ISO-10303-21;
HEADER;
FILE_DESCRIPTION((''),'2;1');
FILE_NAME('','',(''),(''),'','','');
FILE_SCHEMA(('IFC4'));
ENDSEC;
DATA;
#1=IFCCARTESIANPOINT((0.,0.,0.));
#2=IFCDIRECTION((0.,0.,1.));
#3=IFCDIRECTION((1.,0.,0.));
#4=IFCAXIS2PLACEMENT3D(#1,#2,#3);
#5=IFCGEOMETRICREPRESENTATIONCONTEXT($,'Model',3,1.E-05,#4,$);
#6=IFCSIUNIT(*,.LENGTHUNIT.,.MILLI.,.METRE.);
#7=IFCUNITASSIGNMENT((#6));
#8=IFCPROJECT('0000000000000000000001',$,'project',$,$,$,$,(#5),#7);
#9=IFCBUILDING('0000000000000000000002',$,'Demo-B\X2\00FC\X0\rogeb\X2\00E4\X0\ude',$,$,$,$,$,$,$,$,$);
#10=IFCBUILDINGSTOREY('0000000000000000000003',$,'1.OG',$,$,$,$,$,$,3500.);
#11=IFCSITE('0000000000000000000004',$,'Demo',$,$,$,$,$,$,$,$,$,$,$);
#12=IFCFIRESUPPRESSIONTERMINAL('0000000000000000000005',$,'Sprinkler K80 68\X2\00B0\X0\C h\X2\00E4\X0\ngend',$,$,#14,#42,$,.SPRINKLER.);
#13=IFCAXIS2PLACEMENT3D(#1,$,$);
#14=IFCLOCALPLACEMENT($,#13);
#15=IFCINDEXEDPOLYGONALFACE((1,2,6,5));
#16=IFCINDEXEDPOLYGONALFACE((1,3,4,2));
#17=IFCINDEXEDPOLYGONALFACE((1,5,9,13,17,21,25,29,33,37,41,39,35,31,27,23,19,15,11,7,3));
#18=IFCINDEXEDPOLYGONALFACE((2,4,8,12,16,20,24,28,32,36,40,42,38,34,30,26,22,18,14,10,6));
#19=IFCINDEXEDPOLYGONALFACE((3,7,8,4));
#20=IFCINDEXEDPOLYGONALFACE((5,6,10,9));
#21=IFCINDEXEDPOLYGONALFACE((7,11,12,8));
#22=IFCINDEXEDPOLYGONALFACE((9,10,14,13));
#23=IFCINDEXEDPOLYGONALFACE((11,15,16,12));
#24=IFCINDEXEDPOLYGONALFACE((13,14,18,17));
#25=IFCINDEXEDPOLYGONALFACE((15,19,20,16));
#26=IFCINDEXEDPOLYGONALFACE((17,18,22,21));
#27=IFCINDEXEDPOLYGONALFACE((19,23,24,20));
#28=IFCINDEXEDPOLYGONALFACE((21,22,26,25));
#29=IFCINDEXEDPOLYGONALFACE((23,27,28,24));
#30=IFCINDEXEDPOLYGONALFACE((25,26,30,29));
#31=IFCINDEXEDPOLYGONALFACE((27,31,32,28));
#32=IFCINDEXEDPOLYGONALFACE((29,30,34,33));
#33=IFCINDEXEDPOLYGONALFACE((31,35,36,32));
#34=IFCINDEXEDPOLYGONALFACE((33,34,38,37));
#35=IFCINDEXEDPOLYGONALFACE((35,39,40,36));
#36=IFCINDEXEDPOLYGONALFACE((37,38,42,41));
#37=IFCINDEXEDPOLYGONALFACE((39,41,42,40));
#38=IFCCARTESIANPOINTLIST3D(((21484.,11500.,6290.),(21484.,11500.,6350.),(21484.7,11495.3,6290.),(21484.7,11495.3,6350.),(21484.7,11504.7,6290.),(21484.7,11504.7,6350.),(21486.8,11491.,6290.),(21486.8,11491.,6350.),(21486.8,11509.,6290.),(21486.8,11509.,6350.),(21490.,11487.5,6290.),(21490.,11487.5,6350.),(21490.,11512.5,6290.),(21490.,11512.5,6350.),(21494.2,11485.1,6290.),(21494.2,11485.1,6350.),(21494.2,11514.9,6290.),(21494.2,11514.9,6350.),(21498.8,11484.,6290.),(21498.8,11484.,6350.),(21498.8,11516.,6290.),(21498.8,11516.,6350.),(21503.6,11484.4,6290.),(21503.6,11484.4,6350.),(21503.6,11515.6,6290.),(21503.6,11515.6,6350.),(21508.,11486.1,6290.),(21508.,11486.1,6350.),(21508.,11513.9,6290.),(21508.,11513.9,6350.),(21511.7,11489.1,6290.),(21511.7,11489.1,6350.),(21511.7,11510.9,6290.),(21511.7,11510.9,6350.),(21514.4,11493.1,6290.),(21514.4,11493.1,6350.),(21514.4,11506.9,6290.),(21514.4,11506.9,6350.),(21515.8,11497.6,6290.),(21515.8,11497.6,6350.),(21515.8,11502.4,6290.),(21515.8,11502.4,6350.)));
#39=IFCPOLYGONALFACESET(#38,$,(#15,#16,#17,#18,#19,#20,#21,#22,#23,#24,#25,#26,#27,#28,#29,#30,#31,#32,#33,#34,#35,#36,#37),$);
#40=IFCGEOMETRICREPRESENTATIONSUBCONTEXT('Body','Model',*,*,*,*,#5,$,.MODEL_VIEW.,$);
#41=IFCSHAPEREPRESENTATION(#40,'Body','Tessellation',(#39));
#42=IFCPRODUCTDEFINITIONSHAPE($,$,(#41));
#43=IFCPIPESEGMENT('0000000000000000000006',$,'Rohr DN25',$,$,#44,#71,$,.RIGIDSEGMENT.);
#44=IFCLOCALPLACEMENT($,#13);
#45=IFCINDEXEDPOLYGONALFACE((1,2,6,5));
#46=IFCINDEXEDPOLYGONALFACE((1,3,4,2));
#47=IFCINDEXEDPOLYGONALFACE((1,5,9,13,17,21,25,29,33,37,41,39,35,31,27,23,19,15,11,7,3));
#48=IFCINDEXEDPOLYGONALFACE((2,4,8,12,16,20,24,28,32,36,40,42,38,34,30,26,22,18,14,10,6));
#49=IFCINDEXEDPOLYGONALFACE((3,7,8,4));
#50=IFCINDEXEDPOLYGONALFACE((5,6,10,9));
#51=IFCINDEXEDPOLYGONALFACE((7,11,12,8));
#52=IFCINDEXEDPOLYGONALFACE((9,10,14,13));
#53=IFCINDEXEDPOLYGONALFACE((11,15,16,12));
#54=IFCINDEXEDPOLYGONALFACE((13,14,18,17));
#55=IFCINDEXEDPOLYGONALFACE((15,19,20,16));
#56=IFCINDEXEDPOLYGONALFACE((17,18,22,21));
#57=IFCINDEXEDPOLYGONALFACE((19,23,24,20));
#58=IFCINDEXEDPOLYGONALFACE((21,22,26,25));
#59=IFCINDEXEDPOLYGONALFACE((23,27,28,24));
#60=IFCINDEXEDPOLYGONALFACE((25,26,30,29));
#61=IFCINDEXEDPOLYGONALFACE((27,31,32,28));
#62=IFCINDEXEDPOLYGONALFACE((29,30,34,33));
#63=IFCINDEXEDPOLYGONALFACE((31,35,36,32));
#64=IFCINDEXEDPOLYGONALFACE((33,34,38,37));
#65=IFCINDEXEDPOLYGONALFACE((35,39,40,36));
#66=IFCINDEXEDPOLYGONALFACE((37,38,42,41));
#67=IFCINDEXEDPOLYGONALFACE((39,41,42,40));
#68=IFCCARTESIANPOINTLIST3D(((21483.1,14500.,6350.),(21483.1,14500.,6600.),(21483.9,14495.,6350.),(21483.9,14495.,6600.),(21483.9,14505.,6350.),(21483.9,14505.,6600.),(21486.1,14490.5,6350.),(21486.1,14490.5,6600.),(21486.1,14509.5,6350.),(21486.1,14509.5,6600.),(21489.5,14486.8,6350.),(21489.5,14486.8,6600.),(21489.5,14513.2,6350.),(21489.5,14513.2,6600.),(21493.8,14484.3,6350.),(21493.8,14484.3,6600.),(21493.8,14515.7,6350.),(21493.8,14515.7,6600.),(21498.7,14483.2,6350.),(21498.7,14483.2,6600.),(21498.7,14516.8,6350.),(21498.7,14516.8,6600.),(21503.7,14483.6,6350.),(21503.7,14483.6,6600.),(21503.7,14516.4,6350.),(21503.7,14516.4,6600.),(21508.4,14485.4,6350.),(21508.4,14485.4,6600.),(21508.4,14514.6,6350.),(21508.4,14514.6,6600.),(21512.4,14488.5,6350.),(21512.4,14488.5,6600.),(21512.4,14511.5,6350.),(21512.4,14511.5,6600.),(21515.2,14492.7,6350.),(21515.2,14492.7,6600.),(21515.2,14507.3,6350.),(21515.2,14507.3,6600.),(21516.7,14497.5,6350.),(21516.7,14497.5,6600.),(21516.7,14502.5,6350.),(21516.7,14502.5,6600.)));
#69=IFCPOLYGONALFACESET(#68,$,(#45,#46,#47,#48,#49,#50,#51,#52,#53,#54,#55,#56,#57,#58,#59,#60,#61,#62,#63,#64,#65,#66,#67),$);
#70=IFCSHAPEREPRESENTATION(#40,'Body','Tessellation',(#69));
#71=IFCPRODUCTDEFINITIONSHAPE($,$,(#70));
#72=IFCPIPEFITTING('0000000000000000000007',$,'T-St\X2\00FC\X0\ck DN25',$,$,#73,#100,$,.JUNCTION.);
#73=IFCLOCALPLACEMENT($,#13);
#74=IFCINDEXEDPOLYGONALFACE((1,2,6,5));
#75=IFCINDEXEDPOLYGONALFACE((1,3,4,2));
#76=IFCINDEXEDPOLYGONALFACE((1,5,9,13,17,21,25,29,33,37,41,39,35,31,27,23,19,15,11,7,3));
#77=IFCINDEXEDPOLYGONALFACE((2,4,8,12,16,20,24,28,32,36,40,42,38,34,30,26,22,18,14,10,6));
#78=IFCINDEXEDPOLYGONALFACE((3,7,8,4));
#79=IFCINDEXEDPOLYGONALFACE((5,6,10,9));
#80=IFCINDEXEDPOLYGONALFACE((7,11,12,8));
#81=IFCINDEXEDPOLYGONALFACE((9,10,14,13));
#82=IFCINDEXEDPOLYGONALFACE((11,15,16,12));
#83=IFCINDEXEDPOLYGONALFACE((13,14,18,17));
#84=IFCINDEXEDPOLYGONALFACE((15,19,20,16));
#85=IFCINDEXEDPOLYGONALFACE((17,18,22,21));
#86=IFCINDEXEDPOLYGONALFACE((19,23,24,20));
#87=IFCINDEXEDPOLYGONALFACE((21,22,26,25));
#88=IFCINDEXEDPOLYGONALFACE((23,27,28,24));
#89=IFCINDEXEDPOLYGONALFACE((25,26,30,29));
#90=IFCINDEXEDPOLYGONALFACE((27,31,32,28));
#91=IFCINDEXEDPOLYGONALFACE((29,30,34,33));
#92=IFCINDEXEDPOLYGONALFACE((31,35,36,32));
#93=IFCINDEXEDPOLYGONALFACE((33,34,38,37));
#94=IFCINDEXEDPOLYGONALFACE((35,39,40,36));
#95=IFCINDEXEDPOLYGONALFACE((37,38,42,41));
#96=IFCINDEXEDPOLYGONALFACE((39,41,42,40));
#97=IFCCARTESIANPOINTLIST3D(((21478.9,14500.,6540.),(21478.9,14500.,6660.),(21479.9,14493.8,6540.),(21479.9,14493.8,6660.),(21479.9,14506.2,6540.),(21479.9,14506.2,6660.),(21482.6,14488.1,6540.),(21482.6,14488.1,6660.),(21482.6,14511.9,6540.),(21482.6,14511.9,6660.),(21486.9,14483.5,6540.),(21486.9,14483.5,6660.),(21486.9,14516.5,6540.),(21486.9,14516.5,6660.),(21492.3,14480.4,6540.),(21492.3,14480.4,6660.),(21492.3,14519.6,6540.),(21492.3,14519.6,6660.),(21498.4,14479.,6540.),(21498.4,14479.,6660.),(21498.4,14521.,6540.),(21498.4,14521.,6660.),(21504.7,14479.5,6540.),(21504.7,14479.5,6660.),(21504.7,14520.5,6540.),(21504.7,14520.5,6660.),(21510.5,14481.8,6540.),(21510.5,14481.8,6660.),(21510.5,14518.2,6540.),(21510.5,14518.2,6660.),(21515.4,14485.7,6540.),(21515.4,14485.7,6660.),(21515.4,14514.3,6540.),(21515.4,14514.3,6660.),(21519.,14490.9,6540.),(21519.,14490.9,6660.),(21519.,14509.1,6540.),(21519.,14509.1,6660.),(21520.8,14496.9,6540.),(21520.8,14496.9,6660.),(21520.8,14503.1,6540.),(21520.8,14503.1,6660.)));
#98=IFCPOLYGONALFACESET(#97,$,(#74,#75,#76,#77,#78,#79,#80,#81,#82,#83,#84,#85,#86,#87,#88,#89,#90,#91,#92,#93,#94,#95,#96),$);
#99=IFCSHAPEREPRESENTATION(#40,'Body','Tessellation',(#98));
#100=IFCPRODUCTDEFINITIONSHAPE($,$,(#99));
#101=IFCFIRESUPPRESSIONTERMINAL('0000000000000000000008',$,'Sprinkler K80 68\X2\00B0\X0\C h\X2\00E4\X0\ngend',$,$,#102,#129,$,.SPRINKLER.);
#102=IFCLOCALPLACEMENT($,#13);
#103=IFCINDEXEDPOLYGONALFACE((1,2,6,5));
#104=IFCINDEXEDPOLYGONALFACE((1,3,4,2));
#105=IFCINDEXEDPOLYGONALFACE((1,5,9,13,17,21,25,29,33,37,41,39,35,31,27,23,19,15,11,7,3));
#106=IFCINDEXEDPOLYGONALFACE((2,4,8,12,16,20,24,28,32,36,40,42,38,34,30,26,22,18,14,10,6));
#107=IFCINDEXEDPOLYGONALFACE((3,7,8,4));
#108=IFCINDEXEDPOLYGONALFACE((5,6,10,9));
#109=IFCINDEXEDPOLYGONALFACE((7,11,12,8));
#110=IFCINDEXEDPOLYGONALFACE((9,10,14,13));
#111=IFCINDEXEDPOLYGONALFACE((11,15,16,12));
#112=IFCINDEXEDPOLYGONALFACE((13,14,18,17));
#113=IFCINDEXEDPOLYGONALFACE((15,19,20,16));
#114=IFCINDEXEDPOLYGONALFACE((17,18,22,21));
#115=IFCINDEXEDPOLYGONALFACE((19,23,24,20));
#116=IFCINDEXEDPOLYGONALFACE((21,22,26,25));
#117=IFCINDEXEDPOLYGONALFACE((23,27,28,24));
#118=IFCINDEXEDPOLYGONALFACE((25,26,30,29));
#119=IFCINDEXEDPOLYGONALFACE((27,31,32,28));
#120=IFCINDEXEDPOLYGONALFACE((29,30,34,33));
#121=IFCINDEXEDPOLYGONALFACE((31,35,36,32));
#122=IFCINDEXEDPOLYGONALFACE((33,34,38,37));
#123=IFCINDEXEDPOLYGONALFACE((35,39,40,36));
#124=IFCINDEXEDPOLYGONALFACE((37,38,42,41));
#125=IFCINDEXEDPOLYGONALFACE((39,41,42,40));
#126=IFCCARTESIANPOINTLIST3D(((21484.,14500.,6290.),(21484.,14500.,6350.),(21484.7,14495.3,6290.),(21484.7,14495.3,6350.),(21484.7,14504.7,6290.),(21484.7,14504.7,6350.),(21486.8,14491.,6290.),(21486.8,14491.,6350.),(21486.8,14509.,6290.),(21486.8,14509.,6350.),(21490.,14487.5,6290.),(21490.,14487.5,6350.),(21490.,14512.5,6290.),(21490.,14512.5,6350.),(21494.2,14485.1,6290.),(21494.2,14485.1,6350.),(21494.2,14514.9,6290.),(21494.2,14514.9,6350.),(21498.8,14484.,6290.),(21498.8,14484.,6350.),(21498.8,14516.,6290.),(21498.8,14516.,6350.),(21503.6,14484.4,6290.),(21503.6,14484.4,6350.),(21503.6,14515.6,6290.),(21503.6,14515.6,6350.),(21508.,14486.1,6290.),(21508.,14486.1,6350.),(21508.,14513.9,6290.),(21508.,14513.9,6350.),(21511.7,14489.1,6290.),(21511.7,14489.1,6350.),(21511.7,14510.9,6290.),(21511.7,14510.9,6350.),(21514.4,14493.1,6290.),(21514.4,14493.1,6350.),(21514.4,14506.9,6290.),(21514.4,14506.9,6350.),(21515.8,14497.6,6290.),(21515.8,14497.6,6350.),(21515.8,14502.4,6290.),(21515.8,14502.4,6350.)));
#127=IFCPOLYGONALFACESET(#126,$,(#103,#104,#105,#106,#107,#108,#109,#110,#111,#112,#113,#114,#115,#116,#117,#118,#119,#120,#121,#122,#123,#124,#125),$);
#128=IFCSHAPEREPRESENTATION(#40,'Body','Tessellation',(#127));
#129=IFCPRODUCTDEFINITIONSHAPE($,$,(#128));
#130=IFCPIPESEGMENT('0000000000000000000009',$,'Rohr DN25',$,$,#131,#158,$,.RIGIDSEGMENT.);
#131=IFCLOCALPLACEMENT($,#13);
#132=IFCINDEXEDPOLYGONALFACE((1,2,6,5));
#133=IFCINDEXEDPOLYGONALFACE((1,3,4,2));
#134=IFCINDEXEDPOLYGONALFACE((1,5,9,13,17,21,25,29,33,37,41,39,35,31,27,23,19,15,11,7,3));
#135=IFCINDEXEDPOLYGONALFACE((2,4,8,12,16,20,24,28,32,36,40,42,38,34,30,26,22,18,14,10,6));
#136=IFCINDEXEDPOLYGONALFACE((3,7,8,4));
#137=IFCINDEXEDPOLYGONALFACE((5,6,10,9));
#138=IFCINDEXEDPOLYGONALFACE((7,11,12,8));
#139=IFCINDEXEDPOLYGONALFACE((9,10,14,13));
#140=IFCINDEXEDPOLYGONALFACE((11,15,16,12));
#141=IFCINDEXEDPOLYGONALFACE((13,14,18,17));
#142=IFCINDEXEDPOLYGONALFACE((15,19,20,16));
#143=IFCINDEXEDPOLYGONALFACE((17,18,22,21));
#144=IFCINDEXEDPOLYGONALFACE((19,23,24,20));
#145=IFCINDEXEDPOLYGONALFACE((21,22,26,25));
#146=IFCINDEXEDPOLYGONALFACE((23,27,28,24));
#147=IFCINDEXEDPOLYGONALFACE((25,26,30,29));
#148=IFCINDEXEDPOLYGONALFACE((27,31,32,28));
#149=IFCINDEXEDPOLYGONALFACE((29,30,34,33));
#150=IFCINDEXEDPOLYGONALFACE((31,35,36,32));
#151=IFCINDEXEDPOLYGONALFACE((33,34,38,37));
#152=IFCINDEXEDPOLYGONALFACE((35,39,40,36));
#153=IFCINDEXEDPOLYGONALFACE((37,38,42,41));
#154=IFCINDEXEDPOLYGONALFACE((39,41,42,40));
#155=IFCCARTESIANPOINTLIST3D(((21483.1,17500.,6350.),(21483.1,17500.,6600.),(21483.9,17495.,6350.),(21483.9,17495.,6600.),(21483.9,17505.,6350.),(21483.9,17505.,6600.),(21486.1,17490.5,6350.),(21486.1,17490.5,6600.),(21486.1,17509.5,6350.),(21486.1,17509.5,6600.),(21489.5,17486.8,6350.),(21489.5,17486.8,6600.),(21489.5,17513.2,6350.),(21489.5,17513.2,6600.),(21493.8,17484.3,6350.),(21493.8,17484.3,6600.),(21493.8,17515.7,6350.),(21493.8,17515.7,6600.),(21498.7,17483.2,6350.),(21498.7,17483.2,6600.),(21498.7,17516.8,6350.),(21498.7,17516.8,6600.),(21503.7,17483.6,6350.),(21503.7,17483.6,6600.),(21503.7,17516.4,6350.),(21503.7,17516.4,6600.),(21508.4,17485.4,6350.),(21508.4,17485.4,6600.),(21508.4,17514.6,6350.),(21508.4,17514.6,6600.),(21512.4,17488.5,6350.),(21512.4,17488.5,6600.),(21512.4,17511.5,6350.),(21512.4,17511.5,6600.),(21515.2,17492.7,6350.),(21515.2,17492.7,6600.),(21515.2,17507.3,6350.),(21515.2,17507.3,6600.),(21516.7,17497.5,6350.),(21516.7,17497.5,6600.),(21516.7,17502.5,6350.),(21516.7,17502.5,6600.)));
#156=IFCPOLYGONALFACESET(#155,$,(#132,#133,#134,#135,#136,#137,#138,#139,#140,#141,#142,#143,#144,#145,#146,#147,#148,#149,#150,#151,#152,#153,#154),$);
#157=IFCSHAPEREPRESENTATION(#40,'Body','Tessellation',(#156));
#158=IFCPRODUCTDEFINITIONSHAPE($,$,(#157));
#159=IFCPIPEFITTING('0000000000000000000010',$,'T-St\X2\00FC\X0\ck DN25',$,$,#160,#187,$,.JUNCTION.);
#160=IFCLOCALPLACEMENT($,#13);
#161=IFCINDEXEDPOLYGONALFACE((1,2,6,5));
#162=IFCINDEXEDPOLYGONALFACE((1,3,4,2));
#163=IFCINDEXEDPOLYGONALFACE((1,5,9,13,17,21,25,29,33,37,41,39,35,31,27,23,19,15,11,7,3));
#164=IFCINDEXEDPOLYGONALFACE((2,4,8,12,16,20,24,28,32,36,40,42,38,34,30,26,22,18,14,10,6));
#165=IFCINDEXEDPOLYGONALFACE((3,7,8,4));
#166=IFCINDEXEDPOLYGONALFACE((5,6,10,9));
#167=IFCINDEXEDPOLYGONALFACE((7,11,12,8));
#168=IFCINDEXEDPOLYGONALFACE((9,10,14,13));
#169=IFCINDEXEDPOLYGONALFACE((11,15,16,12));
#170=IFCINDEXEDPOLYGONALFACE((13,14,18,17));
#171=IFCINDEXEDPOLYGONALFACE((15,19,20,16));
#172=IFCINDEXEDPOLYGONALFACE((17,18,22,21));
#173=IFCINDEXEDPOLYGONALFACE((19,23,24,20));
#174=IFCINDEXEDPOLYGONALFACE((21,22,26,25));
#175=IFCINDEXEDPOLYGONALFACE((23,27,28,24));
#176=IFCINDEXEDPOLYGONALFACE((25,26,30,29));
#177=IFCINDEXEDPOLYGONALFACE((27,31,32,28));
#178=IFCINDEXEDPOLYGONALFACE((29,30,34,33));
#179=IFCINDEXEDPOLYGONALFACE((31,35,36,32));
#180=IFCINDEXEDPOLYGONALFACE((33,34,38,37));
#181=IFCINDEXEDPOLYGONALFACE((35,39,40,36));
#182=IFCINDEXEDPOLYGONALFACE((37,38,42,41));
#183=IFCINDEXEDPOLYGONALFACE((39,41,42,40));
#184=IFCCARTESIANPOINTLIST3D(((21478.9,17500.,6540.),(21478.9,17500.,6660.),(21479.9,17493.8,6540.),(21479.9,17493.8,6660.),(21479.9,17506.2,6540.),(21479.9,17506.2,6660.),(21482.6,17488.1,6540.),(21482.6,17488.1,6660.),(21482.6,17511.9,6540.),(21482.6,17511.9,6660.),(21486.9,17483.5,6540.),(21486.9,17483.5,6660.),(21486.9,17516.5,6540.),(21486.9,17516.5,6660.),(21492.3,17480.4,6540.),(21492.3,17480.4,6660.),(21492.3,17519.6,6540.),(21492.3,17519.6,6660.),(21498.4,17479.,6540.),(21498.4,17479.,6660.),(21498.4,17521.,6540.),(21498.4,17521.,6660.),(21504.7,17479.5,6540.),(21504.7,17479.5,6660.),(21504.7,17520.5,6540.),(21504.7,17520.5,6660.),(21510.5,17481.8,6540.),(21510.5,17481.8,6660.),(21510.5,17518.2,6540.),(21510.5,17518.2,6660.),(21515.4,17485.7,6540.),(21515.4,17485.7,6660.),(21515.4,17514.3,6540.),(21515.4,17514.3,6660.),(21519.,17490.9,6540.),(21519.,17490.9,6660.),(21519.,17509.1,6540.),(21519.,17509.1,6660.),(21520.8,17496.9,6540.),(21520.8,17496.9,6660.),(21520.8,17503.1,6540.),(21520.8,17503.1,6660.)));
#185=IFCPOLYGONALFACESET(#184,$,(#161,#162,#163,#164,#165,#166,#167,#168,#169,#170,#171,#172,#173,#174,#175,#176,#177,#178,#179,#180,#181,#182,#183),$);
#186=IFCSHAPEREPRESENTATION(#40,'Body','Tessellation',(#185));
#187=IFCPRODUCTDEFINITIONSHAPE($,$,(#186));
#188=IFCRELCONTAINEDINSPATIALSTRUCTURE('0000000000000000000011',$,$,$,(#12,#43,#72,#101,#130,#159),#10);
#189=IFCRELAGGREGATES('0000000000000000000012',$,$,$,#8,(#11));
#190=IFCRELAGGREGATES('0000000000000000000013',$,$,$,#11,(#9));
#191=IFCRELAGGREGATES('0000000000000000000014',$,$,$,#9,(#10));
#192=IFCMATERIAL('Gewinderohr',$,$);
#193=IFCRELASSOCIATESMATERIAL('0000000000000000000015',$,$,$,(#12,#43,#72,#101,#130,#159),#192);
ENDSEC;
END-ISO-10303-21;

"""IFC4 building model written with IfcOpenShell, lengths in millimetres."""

from ifc_helpers import new_model, si_unit, frame, origin_with_axes, place, context, subcontext, project, spatial, circle, extrude, material, element, save


model = new_model("IFC4")

# Units and contexts
model_context = context("Model", 3, precision=1e-05, world=origin_with_axes())
body_context = subcontext(model_context, "Body", "Model", "MODEL_VIEW")
ifc_project = project(units=[si_unit("LENGTHUNIT", "METRE", prefix="MILLI")], contexts=[model_context])

# Site, building, storey
site = spatial("IfcSite", under=ifc_project, Name="Demo")
building = spatial("IfcBuilding", under=site, Name="Demo-Bürogebäude")
storey = spatial("IfcBuildingStorey", under=building, Name="1.OG", Elevation=3500.0)

# Shared definitions
ifc_material_1 = material(Name="Gewinderohr")

# Fire suppression terminal
fire_suppression_terminal_1_placement = place(None, frame((21500.0, 11500.0, 6350.0), z_axis=(0.0, 0.0, -1.0), x_axis=(-1.0, 0.0, 0.0)))
element("IfcFireSuppressionTerminal", 1, at=fire_suppression_terminal_1_placement, inside=storey, material=ifc_material_1, Name="Sprinkler K80 68°C hängend", PredefinedType="SPRINKLER", context=body_context, shape_type="SweptSolid", body=[
    extrude(circle(Radius=16.0), origin_with_axes(), (0.0, 0.0, 1.0), 60.0),
])

# Pipe segment
pipe_segment_1_placement = place(None, frame((21500.0, 14500.0, 6600.0), z_axis=(0.0, 0.0, -1.0), x_axis=(-1.0, 0.0, 0.0)))
element("IfcPipeSegment", 2, at=pipe_segment_1_placement, inside=storey, material=ifc_material_1, Name="Rohr DN25", PredefinedType="RIGIDSEGMENT", context=body_context, shape_type="SweptSolid", body=[
    extrude(circle(Radius=16.9), origin_with_axes(), (0.0, 0.0, 1.0), 250.0),
])

# Pipe fitting
pipe_fitting_1_placement = place(None, frame((21500.0, 14500.0, 6660.0), z_axis=(0.0, 0.0, -1.0), x_axis=(-1.0, 0.0, 0.0)))
element("IfcPipeFitting", 3, at=pipe_fitting_1_placement, inside=storey, material=ifc_material_1, Name="T-Stück DN25", PredefinedType="JUNCTION", context=body_context, shape_type="SweptSolid", body=[
    extrude(circle(Radius=21.1), origin_with_axes(), (0.0, 0.0, 1.0), 120.0),
])

# Fire suppression terminal
fire_suppression_terminal_2_placement = place(None, frame((21500.0, 14500.0, 6350.0), z_axis=(0.0, 0.0, -1.0), x_axis=(-1.0, 0.0, 0.0)))
element("IfcFireSuppressionTerminal", 4, at=fire_suppression_terminal_2_placement, inside=storey, material=ifc_material_1, Name="Sprinkler K80 68°C hängend", PredefinedType="SPRINKLER", context=body_context, shape_type="SweptSolid", body=[
    extrude(circle(Radius=16.0), origin_with_axes(), (0.0, 0.0, 1.0), 60.0),
])

# Pipe segment
pipe_segment_2_placement = place(None, frame((21500.0, 17500.0, 6600.0), z_axis=(0.0, 0.0, -1.0), x_axis=(-1.0, 0.0, 0.0)))
element("IfcPipeSegment", 5, at=pipe_segment_2_placement, inside=storey, material=ifc_material_1, Name="Rohr DN25", PredefinedType="RIGIDSEGMENT", context=body_context, shape_type="SweptSolid", body=[
    extrude(circle(Radius=16.9), origin_with_axes(), (0.0, 0.0, 1.0), 250.0),
])

# Pipe fitting
pipe_fitting_2_placement = place(None, frame((21500.0, 17500.0, 6660.0), z_axis=(0.0, 0.0, -1.0), x_axis=(-1.0, 0.0, 0.0)))
element("IfcPipeFitting", 6, at=pipe_fitting_2_placement, inside=storey, material=ifc_material_1, Name="T-Stück DN25", PredefinedType="JUNCTION", context=body_context, shape_type="SweptSolid", body=[
    extrude(circle(Radius=21.1), origin_with_axes(), (0.0, 0.0, 1.0), 120.0),
])

save(model, "model.ifc")
